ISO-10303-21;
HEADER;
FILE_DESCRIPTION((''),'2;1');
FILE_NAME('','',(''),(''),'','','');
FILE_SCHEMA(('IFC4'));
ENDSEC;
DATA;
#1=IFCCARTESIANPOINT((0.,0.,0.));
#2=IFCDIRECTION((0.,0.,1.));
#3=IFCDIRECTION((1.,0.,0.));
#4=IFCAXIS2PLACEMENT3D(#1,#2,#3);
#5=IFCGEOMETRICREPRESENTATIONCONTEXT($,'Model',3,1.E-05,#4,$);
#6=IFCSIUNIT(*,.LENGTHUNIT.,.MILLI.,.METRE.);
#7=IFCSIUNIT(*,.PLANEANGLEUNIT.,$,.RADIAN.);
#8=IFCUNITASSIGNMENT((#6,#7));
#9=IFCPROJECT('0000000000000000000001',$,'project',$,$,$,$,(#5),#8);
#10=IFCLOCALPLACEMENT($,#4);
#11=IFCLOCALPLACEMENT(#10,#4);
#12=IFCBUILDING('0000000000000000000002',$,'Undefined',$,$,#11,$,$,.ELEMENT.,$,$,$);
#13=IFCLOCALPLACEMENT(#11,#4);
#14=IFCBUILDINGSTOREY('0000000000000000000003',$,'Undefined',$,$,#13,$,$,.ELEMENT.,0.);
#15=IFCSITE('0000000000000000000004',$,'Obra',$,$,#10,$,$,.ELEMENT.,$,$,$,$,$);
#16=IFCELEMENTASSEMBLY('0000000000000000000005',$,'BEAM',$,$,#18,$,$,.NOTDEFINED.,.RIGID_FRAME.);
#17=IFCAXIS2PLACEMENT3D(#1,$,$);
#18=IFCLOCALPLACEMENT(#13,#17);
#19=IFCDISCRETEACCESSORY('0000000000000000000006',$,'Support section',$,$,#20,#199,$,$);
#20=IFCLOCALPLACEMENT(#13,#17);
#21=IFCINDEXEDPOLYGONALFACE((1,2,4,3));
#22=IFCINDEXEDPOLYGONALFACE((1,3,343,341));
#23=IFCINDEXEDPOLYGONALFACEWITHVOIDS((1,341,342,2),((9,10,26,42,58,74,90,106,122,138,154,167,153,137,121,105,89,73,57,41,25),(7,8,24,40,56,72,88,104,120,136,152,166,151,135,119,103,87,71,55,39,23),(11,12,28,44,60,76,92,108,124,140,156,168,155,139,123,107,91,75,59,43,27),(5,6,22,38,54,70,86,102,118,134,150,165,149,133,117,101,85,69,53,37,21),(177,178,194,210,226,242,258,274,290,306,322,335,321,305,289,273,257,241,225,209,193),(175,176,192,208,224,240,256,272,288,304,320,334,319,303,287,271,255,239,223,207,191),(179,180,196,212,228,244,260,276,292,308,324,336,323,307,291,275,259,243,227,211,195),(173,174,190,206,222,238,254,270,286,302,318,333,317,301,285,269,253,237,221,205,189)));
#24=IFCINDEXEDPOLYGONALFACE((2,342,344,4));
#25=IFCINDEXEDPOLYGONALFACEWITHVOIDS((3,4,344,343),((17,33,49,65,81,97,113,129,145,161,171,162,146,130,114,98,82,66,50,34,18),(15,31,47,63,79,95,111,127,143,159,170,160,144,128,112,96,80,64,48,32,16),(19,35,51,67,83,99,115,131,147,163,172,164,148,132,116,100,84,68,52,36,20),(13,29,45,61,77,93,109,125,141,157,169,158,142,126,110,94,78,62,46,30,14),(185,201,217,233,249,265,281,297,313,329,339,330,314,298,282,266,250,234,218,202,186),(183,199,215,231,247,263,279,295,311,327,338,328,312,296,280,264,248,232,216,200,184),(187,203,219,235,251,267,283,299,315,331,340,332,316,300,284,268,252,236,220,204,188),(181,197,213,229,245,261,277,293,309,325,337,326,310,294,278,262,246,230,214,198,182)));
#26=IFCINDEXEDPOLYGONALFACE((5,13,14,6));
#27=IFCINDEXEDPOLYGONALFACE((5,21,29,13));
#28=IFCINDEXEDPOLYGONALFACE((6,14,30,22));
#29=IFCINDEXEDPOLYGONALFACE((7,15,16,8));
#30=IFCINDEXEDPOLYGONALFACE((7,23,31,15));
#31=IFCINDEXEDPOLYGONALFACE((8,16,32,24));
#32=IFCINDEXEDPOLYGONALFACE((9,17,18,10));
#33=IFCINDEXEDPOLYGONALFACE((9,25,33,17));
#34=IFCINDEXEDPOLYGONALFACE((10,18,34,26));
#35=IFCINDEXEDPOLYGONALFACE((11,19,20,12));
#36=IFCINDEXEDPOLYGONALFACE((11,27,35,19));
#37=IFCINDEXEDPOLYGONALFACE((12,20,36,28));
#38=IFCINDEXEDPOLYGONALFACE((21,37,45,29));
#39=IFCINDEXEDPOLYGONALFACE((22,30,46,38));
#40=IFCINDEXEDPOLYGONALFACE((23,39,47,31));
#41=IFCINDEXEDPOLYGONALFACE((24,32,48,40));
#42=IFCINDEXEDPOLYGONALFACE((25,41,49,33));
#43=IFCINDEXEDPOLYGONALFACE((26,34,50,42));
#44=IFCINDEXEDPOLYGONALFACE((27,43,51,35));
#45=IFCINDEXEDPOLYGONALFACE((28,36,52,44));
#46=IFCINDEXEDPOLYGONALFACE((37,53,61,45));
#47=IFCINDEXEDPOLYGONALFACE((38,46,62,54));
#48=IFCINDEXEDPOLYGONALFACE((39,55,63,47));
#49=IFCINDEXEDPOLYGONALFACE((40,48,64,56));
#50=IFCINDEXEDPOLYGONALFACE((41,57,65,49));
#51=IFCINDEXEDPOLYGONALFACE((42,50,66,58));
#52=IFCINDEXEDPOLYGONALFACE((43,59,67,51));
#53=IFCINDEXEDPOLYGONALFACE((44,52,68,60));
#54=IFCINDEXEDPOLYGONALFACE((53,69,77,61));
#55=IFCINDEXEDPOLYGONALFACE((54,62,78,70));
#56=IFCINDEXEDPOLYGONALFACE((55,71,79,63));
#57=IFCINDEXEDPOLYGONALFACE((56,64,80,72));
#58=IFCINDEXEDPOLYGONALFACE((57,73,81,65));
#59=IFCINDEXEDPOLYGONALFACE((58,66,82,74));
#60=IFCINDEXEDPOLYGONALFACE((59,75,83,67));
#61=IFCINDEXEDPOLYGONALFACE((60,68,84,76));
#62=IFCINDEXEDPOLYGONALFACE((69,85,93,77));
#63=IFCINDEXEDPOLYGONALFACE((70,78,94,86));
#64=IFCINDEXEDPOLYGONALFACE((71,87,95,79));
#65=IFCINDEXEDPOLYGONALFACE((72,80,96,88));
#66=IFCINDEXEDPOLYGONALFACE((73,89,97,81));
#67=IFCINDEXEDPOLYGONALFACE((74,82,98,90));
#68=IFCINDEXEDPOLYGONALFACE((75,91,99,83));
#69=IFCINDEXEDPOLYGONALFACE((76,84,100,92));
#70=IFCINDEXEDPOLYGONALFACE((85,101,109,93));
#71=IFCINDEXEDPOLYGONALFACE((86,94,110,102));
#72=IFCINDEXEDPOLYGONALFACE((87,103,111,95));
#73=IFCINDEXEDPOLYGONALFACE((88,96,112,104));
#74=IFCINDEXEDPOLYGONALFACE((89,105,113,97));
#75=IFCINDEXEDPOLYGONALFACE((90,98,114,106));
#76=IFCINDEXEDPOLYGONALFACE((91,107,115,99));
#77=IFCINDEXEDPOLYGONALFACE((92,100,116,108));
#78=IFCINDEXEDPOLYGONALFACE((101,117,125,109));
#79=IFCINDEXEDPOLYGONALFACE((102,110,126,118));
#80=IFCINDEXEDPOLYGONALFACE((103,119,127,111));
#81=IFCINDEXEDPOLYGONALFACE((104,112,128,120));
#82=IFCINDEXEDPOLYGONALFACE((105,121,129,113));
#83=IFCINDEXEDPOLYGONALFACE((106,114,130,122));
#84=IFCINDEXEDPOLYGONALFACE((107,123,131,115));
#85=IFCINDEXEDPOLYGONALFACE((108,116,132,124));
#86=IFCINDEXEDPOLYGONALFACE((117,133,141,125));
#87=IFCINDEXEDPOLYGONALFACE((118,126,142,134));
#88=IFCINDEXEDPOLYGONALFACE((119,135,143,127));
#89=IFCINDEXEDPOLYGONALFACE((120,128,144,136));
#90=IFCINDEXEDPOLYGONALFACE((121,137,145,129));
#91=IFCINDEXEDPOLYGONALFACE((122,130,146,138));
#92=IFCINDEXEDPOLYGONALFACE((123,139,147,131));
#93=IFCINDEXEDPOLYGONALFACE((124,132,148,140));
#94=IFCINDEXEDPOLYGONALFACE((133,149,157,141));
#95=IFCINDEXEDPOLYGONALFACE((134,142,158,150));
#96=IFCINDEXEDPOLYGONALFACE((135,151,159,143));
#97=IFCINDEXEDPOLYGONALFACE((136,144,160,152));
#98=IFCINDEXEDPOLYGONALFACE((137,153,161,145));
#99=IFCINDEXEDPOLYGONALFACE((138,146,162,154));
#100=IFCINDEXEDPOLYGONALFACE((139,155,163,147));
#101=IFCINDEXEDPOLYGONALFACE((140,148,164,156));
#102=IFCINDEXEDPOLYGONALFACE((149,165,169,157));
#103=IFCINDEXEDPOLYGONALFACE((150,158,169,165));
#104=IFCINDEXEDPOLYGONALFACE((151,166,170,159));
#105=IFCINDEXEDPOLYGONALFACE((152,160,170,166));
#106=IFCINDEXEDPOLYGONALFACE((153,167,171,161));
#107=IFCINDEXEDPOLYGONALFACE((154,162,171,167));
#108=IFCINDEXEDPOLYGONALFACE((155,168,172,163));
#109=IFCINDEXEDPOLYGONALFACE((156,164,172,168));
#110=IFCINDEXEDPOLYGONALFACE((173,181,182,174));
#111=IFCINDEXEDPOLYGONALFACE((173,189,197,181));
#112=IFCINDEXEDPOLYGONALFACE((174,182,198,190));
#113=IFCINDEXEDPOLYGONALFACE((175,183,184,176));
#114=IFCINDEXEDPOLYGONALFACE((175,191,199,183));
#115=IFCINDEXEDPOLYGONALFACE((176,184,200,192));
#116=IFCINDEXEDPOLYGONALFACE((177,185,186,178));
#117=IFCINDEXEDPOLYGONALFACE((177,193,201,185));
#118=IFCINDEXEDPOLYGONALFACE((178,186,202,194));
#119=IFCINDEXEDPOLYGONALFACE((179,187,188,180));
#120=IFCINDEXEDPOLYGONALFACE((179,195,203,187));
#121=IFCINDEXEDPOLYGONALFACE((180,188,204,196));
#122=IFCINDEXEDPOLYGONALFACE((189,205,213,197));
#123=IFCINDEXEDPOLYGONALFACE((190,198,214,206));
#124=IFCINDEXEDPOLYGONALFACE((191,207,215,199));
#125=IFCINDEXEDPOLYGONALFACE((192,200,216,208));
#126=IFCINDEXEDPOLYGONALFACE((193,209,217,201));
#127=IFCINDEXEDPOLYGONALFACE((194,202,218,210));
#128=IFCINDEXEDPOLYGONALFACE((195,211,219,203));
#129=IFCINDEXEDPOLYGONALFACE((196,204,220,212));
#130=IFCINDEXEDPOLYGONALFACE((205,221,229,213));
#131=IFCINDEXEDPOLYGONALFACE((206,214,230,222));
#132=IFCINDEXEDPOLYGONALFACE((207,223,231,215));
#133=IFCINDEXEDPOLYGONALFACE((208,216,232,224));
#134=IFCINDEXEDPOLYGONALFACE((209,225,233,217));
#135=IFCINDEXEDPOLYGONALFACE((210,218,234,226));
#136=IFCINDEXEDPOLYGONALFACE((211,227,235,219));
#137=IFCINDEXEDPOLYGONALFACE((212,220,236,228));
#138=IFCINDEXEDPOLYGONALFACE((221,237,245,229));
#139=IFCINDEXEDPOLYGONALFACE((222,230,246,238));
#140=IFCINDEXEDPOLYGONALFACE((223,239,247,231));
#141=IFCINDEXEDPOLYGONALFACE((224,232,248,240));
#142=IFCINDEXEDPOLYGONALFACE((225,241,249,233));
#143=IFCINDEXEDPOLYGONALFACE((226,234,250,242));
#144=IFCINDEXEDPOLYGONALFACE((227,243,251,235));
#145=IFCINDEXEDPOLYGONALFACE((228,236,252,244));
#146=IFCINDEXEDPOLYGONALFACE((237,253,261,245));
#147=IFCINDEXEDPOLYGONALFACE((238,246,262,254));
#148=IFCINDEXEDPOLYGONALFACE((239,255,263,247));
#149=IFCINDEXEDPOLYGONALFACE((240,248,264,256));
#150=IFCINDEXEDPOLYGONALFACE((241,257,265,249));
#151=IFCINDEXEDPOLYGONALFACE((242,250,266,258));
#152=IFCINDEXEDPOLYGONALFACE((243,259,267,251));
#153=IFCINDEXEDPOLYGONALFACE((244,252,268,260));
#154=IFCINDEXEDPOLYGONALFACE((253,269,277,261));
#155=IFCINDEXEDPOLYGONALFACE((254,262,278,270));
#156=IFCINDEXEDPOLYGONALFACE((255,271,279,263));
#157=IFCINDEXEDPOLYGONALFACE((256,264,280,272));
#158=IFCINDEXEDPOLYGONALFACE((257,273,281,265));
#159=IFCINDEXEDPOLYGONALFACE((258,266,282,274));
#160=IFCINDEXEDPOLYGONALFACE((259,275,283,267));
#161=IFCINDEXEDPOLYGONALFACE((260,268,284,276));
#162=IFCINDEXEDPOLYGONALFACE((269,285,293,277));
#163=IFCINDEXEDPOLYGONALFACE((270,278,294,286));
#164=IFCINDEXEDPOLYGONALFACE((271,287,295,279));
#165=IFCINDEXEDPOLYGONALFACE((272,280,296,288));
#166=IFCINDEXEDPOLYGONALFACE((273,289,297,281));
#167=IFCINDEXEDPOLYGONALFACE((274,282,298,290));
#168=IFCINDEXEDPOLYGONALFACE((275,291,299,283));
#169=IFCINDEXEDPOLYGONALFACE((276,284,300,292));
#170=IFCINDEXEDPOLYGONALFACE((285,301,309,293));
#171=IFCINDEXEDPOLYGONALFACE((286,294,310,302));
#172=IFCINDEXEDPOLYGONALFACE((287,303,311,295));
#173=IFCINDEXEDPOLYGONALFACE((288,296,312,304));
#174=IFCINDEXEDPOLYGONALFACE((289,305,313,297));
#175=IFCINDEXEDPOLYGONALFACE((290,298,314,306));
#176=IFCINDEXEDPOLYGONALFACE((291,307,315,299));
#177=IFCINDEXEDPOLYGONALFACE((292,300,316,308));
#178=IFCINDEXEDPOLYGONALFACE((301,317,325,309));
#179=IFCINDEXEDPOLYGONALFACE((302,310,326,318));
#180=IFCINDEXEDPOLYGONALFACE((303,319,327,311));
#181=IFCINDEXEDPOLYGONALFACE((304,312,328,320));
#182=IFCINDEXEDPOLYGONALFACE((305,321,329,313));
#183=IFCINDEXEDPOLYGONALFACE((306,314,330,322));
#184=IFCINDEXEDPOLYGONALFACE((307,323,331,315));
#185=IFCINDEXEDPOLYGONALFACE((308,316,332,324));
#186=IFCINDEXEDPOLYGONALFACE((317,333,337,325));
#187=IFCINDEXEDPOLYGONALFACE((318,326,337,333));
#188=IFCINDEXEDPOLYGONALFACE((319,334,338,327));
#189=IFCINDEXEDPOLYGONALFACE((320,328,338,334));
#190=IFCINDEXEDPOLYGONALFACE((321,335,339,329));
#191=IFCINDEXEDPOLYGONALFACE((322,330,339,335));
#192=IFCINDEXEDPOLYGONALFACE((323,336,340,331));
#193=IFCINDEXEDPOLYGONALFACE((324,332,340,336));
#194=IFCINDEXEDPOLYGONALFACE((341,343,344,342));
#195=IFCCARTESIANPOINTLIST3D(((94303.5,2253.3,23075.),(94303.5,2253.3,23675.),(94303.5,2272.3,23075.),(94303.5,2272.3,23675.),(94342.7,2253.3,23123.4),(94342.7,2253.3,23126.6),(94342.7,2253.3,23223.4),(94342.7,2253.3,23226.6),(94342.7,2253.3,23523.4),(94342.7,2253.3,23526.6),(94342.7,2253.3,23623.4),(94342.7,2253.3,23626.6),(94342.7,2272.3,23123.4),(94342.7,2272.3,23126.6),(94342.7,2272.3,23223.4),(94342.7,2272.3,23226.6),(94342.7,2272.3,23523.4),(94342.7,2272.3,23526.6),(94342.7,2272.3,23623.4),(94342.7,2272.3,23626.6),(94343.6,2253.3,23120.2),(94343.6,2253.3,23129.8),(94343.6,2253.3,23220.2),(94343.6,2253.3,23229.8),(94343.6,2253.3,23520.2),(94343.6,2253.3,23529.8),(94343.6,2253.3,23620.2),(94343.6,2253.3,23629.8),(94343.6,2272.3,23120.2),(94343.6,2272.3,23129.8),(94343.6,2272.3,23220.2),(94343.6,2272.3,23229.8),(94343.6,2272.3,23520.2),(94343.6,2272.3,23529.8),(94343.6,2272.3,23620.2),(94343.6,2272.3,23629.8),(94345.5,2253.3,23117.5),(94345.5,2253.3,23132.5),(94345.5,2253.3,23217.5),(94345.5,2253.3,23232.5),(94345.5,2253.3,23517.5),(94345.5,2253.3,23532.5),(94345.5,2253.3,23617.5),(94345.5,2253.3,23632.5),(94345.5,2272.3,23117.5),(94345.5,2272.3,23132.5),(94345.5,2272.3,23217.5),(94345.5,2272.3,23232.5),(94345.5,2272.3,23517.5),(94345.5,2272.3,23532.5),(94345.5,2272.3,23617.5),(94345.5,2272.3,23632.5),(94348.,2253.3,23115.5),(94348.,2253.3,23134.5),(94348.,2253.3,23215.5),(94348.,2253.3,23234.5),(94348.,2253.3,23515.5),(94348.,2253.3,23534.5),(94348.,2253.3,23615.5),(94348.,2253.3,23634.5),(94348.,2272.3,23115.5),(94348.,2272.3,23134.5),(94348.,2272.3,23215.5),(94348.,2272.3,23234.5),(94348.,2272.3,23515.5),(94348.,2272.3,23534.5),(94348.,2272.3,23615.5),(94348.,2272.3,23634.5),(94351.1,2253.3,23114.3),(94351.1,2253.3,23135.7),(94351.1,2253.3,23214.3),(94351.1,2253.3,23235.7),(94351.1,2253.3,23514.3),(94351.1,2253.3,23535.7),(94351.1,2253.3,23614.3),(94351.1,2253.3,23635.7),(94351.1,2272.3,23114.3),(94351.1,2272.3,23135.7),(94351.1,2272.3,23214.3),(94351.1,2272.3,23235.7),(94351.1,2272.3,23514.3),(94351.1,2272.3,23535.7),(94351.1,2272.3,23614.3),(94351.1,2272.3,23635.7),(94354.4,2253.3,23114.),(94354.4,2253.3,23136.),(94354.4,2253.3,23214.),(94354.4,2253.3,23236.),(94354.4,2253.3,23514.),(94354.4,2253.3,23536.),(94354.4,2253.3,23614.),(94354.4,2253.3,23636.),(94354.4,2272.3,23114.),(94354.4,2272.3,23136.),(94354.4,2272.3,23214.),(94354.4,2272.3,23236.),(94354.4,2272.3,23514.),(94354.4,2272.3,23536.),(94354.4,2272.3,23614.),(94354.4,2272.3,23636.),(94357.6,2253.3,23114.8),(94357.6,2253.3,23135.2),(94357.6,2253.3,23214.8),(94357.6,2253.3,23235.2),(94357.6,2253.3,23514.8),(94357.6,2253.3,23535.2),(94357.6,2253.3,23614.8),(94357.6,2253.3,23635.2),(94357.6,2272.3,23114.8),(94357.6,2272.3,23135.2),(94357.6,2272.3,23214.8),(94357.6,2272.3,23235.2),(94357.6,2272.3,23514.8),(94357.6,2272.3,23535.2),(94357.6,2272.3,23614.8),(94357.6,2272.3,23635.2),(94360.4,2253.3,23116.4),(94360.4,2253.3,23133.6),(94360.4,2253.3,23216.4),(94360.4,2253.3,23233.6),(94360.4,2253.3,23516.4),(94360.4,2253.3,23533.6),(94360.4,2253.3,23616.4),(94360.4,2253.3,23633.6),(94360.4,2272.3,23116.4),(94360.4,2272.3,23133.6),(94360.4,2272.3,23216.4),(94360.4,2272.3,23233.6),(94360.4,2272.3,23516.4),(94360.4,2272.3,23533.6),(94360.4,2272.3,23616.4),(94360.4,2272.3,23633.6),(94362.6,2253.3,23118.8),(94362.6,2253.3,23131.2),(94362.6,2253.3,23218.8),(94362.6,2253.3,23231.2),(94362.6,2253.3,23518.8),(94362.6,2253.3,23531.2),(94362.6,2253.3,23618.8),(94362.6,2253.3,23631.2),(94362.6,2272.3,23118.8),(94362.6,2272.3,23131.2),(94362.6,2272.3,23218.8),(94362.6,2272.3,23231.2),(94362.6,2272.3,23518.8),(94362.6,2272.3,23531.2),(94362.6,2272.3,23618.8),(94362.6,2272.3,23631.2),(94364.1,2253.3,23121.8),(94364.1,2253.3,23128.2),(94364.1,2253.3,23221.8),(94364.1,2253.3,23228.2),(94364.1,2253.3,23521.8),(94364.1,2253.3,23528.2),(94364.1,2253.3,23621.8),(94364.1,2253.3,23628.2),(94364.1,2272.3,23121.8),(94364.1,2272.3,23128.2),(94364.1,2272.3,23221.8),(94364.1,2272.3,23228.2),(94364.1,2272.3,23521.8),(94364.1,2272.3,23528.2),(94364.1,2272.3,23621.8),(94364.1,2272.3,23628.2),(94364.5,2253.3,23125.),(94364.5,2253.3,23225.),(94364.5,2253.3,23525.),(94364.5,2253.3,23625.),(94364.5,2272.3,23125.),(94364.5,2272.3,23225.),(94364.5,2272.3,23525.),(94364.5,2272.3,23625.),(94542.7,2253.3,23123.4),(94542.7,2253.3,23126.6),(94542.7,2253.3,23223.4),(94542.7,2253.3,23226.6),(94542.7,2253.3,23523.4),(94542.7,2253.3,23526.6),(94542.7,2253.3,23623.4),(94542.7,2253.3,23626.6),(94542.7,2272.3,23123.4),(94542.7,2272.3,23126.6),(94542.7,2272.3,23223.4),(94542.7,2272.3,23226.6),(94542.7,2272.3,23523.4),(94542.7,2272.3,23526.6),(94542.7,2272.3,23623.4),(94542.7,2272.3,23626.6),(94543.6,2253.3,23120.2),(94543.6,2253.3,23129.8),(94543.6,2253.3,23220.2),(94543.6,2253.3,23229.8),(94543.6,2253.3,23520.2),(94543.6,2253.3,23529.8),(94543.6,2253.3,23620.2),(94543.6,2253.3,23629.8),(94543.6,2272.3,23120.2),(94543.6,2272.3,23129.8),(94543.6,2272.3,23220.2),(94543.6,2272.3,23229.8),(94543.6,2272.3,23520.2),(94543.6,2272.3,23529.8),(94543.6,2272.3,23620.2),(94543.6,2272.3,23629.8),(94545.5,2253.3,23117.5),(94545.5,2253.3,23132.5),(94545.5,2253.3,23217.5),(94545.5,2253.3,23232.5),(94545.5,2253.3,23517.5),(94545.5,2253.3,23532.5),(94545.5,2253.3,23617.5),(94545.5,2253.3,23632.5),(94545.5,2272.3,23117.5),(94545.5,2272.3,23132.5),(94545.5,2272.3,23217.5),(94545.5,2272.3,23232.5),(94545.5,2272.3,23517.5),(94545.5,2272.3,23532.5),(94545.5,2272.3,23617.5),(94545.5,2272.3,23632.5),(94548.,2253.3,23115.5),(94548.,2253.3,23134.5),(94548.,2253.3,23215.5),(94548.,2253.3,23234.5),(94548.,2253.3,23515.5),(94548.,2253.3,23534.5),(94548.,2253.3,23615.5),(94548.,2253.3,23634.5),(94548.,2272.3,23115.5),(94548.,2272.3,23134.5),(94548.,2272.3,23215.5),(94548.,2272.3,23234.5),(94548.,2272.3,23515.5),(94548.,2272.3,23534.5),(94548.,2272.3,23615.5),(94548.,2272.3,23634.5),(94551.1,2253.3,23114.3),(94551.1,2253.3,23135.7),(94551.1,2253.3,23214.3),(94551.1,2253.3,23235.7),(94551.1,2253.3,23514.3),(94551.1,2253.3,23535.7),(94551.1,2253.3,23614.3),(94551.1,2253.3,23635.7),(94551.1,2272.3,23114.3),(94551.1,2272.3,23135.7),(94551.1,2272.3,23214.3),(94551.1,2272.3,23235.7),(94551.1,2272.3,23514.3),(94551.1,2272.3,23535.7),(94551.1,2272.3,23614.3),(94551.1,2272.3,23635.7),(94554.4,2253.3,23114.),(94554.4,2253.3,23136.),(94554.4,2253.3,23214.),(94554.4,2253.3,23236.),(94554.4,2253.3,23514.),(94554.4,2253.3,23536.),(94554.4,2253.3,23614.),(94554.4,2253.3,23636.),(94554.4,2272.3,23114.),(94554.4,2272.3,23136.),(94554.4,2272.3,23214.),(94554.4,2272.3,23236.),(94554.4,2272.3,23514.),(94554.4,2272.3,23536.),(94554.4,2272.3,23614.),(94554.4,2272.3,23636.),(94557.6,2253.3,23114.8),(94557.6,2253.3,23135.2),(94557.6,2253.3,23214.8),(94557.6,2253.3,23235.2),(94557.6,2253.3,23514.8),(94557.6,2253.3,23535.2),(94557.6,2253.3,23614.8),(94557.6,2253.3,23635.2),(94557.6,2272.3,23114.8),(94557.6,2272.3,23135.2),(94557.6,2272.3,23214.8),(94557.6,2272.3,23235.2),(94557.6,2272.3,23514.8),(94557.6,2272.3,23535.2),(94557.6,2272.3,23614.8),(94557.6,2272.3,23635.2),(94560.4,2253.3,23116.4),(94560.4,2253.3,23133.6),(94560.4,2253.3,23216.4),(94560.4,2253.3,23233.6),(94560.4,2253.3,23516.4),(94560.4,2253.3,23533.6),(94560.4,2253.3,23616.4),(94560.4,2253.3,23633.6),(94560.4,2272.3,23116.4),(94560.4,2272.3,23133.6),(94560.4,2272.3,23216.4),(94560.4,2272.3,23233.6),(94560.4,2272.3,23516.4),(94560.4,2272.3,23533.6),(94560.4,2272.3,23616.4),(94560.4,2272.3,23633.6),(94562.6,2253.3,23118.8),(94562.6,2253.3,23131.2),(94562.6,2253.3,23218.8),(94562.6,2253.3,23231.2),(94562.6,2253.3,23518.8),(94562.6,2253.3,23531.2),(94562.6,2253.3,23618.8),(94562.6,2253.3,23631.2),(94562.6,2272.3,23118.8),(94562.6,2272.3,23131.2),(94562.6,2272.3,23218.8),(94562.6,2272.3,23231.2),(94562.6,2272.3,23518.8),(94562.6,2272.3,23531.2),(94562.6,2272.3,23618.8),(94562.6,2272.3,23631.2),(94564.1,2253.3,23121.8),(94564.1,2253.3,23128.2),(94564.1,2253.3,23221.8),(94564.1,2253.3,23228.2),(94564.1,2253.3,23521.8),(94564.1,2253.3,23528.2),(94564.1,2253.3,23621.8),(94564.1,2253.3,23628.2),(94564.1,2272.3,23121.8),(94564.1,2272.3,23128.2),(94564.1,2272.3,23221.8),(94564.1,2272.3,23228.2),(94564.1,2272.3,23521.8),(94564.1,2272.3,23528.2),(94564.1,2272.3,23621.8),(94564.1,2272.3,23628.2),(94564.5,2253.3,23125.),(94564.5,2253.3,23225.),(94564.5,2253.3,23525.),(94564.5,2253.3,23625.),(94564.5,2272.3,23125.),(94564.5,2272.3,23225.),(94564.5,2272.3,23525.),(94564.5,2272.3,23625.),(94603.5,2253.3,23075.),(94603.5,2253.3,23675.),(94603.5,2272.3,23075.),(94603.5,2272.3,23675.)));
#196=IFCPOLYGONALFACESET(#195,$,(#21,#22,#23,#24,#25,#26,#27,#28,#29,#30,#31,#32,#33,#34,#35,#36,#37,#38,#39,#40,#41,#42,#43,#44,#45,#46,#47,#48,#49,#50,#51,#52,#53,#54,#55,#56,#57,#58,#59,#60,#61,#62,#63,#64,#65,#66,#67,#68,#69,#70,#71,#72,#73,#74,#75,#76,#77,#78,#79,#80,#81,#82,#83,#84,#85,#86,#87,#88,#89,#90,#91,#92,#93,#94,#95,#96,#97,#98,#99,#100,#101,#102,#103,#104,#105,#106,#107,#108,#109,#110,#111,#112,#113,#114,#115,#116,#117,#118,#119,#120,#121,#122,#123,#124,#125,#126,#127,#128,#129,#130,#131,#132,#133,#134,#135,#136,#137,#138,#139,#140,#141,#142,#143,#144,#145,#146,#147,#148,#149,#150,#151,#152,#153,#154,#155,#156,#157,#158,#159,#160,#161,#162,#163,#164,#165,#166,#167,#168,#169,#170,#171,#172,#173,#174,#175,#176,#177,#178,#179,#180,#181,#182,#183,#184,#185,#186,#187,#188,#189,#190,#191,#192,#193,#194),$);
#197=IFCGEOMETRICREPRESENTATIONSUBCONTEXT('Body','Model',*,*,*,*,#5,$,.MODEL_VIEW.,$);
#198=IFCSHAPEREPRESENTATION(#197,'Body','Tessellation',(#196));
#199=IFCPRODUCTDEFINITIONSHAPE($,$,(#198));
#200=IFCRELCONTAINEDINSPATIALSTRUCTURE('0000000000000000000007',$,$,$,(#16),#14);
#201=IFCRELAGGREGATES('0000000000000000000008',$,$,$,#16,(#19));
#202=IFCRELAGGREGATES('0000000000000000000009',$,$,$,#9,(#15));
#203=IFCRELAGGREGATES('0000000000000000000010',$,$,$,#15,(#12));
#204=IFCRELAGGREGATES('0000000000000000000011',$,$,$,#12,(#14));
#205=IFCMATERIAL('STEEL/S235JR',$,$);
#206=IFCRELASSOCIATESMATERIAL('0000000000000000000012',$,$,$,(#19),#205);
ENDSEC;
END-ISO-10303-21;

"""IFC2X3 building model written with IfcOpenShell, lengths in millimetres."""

from ifc_helpers import new_model, si_unit, frame, origin_with_axes, origin_2d_with_axis, place, context, subcontext, project, spatial, rectangle, circle, extrude, source, transform, mapped, material, element, aggregate, save


model = new_model("IFC2X3")

# Units and contexts
model_context = context("Model", 3, precision=1e-05, world=origin_with_axes())
body_context = subcontext(model_context, "Body", "Model", "MODEL_VIEW")
ifc_project = project(units=[si_unit("LENGTHUNIT", "METRE", prefix="MILLI"), si_unit("PLANEANGLEUNIT", "RADIAN")], contexts=[model_context])

# Site, building, storey
site_placement = place(None, origin_with_axes())
site = spatial("IfcSite", under=ifc_project, at=site_placement, Name="Obra", CompositionType="ELEMENT")
building_placement = place(site_placement, origin_with_axes())
building = spatial("IfcBuilding", under=site, at=building_placement, Name="Undefined", CompositionType="ELEMENT")
storey_placement = place(building_placement, origin_with_axes())
storey = spatial("IfcBuildingStorey", under=building, at=storey_placement, Name="Undefined", CompositionType="ELEMENT", Elevation=0.0)

# Element assembly
assembly_1_placement = place(storey_placement, origin_with_axes())
assembly_1 = element("IfcElementAssembly", 1, at=assembly_1_placement, inside=storey, Name="BEAM", AssemblyPlace="NOTDEFINED", PredefinedType="RIGID_FRAME")
ifc_material_1 = material(Name="STEEL/S235JR")

# Discrete accessory, opening
discrete_accessory_1_placement = place(assembly_1_placement, frame((94603.5, 2262.8, 23375.0), z_axis=(0.0, 0.0, 1.0), x_axis=(-1.0, 0.0, 0.0)))
discrete_accessory_1 = element("IfcDiscreteAccessory", 2, at=discrete_accessory_1_placement, material=ifc_material_1, Name="Support section", context=body_context, shape_type="SweptSolid", body=[
    extrude(rectangle(XDim=19.0, YDim=600.0, at=origin_2d_with_axis()), frame((300.0, 0.0, 0.0), z_axis=(-1.0, 0.0, 0.0), x_axis=(0.0, -1.0, 0.0)), (0.0, 0.0, 1.0), 300.0),
])
shared_shape_1 = source(origin_with_axes(), body_context, "Body", "SweptSolid", [
    extrude(circle(Radius=11.0, at=origin_2d_with_axis()), frame((0.0, -0.1, 0.0), z_axis=(0.0, 1.0, 0.0), x_axis=(1.0, 0.0, 0.0)), (0.0, 0.0, 1.0), 19.2),
])
opening_1_placement = place(assembly_1_placement, frame((94358.5, 2253.3, 23375.0), z_axis=(0.0, 0.0, 1.0), x_axis=(1.0, 0.0, 0.0)))
element("IfcOpeningElement", 3, at=opening_1_placement, cuts=discrete_accessory_1, ObjectType="Opening", context=body_context, shape_type="MappedRepresentation", body=[
    mapped(shared_shape_1, transform((-5.0, 0.0, -250.0))),
    mapped(shared_shape_1, transform((-5.0, 0.0, -150.0))),
    mapped(shared_shape_1, transform((-5.0, 0.0, 150.0))),
    mapped(shared_shape_1, transform((-5.0, 0.0, 250.0))),
    mapped(shared_shape_1, transform((195.0, 0.0, -250.0))),
    mapped(shared_shape_1, transform((195.0, 0.0, -150.0))),
    mapped(shared_shape_1, transform((195.0, 0.0, 150.0))),
    mapped(shared_shape_1, transform((195.0, 0.0, 250.0))),
])
aggregate(assembly_1, [discrete_accessory_1])

save(model, "model.ifc")
